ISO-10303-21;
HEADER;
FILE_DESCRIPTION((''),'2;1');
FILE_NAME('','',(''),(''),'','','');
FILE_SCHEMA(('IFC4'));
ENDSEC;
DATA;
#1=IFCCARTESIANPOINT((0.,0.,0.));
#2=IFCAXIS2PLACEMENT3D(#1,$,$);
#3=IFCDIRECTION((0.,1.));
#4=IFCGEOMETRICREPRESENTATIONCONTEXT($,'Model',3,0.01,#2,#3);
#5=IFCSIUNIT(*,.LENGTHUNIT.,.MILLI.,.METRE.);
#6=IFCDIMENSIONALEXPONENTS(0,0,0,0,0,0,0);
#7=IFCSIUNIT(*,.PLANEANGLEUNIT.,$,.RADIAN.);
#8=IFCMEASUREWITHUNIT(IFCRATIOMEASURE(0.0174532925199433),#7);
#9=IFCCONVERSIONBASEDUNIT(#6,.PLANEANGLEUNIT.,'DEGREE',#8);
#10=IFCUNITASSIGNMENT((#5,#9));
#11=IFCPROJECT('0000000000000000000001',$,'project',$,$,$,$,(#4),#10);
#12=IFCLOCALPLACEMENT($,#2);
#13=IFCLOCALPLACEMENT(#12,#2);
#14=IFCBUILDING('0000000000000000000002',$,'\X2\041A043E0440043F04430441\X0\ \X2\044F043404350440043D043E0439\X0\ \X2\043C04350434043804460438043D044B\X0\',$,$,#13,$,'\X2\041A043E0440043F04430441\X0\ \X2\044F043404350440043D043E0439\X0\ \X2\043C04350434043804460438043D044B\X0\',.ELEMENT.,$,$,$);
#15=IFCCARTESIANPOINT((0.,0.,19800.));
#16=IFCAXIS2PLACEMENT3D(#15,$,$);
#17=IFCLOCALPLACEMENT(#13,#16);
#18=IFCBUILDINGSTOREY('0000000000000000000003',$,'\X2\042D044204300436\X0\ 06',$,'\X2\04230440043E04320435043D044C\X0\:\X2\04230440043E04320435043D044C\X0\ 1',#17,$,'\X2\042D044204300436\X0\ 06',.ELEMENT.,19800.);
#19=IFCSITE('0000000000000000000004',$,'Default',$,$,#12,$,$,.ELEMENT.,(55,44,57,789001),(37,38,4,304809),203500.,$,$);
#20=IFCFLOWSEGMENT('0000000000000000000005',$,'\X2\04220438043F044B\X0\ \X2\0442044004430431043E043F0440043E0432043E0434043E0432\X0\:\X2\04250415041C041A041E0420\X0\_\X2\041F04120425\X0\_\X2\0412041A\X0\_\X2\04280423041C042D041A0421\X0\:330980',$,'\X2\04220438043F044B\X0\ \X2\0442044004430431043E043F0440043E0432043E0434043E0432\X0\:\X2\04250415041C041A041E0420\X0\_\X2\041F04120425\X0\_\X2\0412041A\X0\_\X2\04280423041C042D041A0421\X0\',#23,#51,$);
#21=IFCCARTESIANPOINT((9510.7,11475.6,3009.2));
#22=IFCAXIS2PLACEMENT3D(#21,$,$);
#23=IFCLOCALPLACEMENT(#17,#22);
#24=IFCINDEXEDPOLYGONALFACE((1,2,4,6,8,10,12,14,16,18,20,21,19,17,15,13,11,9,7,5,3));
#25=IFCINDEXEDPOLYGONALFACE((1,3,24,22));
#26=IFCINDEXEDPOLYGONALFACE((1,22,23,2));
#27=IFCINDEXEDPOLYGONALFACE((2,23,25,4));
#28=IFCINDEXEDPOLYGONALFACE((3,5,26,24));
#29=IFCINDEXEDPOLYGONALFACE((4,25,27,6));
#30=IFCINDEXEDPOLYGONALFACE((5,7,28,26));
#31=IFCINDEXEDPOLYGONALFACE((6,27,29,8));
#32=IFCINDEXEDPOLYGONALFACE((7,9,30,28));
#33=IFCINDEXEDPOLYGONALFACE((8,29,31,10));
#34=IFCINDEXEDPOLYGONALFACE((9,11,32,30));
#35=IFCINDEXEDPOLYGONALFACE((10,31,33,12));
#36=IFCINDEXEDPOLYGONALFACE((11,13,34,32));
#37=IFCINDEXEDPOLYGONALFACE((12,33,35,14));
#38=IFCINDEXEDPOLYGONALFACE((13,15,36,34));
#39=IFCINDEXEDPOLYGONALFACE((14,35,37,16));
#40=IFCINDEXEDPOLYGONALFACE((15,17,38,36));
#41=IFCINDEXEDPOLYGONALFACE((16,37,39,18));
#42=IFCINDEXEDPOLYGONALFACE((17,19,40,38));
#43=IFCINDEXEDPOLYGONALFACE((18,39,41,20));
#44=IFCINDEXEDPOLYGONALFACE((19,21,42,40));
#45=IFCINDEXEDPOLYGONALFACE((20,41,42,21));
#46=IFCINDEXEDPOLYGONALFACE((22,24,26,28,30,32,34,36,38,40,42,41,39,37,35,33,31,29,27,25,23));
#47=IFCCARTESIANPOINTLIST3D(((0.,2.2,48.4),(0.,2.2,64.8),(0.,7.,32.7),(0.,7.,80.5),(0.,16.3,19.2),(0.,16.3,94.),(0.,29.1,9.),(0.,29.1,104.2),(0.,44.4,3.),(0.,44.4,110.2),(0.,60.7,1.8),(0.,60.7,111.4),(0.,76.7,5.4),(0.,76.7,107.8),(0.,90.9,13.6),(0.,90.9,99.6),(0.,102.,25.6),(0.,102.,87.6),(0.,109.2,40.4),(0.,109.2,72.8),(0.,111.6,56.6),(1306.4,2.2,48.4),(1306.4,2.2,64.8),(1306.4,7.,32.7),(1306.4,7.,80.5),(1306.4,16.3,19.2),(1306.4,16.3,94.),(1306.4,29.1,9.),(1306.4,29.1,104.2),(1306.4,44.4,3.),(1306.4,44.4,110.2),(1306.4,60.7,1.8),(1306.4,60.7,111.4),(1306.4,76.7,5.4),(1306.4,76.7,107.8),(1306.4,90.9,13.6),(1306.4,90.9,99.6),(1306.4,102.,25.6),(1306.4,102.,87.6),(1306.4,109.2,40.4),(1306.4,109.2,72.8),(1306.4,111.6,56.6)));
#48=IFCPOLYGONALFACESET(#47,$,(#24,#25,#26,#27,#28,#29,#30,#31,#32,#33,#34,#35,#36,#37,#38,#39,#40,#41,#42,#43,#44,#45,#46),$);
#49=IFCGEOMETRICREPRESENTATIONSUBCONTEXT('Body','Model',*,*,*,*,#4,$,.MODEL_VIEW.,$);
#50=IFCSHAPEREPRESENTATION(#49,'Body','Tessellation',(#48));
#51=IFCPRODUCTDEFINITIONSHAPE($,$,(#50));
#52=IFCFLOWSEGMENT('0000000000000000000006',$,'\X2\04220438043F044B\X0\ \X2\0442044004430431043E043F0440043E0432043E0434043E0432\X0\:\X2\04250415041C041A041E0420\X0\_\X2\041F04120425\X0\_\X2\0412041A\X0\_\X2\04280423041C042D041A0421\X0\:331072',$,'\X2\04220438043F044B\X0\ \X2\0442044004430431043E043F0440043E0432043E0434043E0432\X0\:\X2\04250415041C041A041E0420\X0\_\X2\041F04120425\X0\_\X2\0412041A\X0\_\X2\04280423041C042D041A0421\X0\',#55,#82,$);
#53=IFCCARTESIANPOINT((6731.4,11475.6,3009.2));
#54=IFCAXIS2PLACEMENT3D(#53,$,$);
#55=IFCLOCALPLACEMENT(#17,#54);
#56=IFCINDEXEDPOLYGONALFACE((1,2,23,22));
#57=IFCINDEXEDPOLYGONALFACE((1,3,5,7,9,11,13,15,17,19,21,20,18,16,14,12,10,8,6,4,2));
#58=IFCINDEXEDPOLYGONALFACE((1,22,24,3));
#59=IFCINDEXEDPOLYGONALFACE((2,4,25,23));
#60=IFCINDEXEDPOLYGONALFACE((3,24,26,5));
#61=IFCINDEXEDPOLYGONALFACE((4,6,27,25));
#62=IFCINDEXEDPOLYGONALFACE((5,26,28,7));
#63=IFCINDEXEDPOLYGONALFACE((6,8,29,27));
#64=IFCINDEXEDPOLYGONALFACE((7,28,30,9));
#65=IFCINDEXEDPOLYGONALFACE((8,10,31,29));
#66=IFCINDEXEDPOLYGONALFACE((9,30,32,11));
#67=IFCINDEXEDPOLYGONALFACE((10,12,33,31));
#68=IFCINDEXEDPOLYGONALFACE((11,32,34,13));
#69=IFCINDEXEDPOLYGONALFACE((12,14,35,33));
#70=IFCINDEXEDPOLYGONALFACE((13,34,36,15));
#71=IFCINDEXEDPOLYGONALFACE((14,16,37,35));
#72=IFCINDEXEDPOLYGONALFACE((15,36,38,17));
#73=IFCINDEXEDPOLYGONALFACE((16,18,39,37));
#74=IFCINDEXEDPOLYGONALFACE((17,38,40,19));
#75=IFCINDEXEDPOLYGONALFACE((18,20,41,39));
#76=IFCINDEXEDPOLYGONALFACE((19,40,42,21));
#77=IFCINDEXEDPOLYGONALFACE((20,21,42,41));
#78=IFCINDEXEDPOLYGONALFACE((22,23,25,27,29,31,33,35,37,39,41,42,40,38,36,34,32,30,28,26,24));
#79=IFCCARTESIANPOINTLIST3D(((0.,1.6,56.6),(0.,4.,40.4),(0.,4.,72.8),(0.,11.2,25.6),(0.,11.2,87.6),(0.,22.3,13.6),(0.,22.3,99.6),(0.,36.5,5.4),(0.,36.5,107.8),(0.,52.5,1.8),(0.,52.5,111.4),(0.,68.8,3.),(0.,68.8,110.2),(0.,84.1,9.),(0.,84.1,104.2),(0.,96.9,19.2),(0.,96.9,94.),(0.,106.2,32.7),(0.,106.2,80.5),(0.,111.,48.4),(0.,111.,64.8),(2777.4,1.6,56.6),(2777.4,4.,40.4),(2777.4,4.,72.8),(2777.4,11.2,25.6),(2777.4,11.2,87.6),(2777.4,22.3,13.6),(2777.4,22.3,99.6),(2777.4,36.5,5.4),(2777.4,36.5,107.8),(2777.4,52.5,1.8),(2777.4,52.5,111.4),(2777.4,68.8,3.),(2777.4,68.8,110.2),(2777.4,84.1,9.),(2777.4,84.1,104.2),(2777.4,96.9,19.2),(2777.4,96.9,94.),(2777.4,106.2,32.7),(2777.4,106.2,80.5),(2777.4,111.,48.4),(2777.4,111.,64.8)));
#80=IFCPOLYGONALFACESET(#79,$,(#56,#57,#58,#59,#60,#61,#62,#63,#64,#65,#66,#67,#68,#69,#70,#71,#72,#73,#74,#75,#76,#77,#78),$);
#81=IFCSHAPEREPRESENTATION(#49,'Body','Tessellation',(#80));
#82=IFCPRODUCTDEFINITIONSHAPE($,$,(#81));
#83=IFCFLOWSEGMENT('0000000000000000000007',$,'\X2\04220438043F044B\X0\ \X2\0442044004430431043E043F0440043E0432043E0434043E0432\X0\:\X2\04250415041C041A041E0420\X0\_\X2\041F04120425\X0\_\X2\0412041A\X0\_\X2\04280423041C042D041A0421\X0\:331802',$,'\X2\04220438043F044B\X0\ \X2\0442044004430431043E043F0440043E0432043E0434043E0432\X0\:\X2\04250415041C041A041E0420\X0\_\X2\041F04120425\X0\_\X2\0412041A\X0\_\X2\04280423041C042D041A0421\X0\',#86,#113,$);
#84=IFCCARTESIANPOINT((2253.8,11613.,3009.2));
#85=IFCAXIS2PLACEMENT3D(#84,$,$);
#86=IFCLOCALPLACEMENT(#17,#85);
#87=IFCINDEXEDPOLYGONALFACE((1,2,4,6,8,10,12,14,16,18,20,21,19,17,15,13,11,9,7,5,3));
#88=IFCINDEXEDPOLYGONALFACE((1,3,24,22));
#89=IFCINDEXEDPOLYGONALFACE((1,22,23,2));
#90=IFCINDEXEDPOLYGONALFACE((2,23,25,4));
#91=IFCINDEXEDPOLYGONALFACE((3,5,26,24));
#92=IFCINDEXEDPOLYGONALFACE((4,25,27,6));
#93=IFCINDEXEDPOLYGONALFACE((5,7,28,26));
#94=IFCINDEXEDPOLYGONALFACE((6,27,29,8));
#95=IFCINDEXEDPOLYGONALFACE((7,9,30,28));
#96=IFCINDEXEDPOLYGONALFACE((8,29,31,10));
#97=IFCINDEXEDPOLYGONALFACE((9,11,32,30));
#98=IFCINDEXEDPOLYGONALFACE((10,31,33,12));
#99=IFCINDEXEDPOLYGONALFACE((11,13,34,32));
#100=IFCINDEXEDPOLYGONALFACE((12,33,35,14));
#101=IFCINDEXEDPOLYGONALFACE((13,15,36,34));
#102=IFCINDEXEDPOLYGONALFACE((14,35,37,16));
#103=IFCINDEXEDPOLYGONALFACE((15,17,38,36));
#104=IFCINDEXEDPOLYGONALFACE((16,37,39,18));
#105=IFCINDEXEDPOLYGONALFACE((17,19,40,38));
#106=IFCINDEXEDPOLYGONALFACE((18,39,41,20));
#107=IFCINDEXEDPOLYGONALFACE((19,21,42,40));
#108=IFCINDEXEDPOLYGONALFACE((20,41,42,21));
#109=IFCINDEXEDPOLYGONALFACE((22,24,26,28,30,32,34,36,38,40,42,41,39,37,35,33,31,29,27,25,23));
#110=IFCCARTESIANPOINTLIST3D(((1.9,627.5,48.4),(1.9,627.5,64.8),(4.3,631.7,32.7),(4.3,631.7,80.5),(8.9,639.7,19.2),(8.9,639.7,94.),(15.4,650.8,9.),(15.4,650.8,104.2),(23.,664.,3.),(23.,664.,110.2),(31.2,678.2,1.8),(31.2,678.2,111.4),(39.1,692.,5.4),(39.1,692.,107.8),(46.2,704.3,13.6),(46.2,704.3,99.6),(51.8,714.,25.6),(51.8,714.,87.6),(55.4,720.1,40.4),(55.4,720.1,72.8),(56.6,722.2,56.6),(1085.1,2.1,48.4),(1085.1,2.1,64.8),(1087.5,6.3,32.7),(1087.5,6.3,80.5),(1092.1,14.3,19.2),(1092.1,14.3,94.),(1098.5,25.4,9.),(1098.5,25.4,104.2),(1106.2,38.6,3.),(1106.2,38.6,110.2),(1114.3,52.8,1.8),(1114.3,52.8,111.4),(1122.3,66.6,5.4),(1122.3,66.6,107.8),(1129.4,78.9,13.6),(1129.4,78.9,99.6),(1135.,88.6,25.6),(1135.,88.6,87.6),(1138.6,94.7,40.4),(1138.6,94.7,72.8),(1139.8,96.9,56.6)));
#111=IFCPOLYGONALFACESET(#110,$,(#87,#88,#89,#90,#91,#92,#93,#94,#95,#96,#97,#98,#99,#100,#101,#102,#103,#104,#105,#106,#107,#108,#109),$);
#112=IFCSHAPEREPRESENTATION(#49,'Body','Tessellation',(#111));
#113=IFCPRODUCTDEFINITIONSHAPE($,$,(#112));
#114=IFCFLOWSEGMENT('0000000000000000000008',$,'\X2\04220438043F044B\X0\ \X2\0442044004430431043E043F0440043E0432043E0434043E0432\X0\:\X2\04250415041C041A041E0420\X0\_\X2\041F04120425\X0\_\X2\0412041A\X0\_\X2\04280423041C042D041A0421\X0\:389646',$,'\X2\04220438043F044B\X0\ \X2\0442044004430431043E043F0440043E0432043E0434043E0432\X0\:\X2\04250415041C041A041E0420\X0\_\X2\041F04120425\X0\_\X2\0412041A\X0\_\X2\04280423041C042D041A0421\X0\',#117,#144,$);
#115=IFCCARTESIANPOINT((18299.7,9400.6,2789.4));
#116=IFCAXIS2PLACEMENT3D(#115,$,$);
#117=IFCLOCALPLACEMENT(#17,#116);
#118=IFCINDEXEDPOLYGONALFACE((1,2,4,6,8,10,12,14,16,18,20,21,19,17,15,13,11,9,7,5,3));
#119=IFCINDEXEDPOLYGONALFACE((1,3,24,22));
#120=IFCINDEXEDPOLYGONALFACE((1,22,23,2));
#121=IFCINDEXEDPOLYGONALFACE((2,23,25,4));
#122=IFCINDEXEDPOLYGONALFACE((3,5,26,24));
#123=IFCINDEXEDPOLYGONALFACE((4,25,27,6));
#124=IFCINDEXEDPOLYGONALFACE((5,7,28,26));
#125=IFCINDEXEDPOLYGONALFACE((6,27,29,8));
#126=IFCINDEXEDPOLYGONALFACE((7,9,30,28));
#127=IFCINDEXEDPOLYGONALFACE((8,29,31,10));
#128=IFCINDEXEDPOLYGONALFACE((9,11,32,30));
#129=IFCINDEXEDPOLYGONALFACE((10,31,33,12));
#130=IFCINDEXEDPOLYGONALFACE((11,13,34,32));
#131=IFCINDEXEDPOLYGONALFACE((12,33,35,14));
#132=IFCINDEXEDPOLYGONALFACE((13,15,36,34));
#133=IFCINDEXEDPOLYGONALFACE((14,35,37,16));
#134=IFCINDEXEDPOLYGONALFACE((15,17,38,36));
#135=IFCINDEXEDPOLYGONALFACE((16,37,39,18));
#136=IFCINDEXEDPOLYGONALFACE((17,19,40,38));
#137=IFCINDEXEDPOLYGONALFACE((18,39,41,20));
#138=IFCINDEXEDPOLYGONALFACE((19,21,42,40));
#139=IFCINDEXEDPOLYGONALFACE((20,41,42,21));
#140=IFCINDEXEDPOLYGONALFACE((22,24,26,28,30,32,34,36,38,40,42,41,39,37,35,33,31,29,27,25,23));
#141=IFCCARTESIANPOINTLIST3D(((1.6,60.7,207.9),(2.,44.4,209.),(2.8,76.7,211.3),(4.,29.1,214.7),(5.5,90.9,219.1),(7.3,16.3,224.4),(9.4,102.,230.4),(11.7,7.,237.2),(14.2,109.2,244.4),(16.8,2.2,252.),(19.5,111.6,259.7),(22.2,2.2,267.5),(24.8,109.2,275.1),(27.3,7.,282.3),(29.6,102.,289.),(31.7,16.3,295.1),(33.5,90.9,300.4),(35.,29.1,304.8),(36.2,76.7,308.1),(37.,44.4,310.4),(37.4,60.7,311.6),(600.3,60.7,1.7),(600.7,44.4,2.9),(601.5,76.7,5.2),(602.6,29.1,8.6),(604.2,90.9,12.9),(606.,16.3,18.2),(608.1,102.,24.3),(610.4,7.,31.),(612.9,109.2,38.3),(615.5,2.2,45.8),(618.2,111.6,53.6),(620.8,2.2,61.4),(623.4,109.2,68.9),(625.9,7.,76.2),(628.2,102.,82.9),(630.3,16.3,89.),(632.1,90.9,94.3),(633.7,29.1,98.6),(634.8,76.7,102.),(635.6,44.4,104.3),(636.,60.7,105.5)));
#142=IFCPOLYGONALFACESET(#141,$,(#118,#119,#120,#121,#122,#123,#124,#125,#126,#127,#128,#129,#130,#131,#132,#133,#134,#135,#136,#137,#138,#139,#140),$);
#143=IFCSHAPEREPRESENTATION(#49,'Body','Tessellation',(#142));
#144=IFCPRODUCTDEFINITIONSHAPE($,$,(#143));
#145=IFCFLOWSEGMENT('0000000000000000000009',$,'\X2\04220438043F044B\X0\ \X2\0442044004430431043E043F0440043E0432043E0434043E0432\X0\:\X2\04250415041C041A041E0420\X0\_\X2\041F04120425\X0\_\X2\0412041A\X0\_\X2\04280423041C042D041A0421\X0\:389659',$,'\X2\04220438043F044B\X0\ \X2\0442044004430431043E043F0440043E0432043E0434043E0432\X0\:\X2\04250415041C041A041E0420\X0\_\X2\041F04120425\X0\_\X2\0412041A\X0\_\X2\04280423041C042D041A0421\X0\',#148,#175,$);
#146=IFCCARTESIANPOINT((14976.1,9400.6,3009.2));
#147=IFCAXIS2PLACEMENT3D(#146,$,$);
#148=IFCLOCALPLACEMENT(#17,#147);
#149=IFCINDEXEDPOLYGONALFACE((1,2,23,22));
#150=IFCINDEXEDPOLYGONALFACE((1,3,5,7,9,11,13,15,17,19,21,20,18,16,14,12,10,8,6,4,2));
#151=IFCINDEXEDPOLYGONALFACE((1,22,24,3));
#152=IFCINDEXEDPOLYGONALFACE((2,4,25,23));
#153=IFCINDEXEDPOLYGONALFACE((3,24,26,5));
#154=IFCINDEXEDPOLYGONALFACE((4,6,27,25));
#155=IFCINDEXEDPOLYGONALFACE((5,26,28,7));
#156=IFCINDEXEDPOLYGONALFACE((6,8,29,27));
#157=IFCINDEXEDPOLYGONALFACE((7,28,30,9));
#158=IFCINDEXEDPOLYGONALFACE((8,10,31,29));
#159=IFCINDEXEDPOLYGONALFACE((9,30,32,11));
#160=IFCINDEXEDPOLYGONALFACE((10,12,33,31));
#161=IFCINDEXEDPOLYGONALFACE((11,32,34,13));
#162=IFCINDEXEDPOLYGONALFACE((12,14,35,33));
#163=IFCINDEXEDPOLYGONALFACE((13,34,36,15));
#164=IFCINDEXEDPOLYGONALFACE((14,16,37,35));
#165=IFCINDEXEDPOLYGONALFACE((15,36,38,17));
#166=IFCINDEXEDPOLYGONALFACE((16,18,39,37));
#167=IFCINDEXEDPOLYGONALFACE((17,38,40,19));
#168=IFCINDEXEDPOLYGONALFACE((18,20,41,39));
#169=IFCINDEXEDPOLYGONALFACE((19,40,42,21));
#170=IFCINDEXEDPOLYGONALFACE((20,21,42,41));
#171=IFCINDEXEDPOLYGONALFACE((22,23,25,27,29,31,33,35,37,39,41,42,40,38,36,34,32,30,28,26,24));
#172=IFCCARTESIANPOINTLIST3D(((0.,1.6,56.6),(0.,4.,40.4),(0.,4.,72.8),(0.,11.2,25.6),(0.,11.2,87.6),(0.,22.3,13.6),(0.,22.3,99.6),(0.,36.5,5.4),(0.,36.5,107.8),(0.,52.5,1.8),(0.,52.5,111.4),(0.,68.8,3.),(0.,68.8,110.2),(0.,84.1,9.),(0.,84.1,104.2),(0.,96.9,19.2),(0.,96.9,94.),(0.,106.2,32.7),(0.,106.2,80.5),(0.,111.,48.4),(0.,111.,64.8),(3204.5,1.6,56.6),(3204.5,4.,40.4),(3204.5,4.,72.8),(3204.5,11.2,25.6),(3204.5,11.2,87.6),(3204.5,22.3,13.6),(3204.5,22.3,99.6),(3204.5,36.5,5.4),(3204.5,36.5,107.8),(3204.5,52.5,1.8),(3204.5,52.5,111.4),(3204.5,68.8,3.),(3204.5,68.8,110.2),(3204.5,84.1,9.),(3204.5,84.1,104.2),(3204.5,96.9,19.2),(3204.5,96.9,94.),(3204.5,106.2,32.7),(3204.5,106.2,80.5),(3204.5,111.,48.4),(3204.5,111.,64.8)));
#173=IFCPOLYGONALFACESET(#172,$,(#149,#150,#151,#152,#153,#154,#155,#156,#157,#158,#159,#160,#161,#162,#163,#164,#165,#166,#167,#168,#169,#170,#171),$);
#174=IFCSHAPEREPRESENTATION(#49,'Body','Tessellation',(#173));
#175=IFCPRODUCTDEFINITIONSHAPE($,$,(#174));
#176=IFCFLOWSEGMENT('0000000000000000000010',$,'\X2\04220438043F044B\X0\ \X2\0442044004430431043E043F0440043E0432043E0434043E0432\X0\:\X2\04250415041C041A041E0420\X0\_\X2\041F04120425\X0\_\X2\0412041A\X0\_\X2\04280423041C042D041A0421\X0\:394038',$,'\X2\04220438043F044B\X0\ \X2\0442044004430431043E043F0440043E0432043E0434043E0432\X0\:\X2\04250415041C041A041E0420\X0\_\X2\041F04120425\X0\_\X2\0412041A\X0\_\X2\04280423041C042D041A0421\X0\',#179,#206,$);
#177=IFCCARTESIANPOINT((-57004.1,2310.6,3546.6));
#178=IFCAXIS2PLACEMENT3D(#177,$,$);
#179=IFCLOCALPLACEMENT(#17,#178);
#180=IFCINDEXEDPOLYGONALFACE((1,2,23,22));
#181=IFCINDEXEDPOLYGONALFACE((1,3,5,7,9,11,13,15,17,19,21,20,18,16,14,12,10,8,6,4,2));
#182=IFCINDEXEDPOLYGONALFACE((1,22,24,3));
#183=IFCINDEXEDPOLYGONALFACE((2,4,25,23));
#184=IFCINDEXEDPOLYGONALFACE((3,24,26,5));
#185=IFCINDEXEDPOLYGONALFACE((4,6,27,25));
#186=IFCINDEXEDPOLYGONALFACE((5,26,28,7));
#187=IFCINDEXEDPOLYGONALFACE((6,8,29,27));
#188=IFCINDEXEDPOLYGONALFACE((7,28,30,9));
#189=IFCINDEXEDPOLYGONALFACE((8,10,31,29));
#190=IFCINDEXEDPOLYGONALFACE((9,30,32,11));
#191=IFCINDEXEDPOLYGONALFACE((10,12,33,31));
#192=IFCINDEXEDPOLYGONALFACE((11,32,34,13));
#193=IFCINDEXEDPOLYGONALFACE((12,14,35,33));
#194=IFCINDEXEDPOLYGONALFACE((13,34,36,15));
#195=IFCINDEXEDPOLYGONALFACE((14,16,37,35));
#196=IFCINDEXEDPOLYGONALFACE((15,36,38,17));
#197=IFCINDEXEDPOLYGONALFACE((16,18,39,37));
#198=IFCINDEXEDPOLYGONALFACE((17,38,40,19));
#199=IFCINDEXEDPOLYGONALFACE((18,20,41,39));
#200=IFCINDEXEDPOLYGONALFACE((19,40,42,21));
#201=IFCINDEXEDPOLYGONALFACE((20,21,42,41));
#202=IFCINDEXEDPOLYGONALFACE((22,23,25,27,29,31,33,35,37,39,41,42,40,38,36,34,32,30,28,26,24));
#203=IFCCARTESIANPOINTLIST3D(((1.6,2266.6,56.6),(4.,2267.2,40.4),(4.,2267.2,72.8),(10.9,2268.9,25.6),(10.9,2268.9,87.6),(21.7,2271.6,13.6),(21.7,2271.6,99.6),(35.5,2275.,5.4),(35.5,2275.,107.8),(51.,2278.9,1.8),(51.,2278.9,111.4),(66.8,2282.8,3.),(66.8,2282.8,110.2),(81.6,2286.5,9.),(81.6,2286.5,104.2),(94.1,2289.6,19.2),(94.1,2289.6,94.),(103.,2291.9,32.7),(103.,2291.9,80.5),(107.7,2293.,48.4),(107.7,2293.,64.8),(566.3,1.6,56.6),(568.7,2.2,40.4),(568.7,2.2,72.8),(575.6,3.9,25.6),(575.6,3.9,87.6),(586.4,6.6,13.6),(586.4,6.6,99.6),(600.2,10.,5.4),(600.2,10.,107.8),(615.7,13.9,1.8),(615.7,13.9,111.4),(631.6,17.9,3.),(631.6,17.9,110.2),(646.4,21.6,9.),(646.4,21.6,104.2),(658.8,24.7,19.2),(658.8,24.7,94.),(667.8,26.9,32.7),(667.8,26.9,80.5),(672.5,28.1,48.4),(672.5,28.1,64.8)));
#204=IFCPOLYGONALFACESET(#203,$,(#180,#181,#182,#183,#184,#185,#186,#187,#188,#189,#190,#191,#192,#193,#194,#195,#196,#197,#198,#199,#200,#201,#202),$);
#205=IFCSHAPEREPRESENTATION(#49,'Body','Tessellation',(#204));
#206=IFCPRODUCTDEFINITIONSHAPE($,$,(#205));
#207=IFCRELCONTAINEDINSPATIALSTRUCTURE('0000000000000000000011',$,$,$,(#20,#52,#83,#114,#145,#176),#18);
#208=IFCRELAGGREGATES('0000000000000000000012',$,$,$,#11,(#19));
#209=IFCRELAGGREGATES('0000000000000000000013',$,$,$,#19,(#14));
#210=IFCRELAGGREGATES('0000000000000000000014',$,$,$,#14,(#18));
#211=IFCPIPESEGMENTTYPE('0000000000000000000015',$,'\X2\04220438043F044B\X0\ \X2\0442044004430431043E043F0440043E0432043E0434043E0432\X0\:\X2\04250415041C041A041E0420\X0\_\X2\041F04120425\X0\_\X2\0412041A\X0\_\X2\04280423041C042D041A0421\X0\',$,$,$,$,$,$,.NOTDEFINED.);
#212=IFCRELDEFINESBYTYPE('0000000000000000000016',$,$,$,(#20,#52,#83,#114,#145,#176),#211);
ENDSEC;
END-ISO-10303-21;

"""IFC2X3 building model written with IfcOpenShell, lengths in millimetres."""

from ifc_helpers import new_model, entity, si_unit, converted_unit, direction, frame, origin, origin_2d_with_axis, place, context, subcontext, project, spatial, circle, extrude, type_object, element, save


model = new_model("IFC2X3")

# Units and contexts
model_context = context("Model", 3, precision=0.01, world=origin(), true_north=direction((0.0, 1.0)))
body_context = subcontext(model_context, "Body", "Model", "MODEL_VIEW")
ifc_project = project(units=[si_unit("LENGTHUNIT", "METRE", prefix="MILLI"), converted_unit("PLANEANGLEUNIT", "DEGREE", entity("IfcRatioMeasure", 0.0174532925199433), si_unit("PLANEANGLEUNIT", "RADIAN"), dimensions=[0, 0, 0, 0, 0, 0, 0])], contexts=[model_context])

# Site, building, storey
site_placement = place(None, origin())
site = spatial("IfcSite", under=ifc_project, at=site_placement, Name="Default", CompositionType="ELEMENT", RefLatitude=(55, 44, 57, 789001), RefLongitude=(37, 38, 4, 304809), RefElevation=203500.0)
building_placement = place(site_placement, origin())
building = spatial("IfcBuilding", under=site, at=building_placement, Name="Корпус ядерной медицины", LongName="Корпус ядерной медицины", CompositionType="ELEMENT")
storey_placement = place(building_placement, frame((0.0, 0.0, 19800.0)))
storey = spatial("IfcBuildingStorey", under=building, at=storey_placement, Name="Этаж 06", ObjectType="Уровень:Уровень 1", LongName="Этаж 06", CompositionType="ELEMENT", Elevation=19800.0)

# Flow segments
pipe_segment_type = type_object("IfcPipeSegmentType", Name="Типы трубопроводов:ХЕМКОР_ПВХ_ВК_ШУМЭКС", PredefinedType="NOTDEFINED")
flow_segment_1_placement = place(storey_placement, frame((9510.7, 11475.6, 3009.2)))
element("IfcFlowSegment", 1, at=flow_segment_1_placement, inside=storey, type_object=pipe_segment_type, Name="Типы трубопроводов:ХЕМКОР_ПВХ_ВК_ШУМЭКС:330980", ObjectType="Типы трубопроводов:ХЕМКОР_ПВХ_ВК_ШУМЭКС", context=body_context, shape_type="SweptSolid", body=[
    extrude(circle(Radius=55.0, at=origin_2d_with_axis()), frame((0.0, 56.6, 56.6), z_axis=(1.0, 0.0, 0.0), x_axis=(0.0, 1.0, 0.0)), (0.0, 0.0, 1.0), 1306.4),
])
flow_segment_2_placement = place(storey_placement, frame((6731.4, 11475.6, 3009.2)))
element("IfcFlowSegment", 2, at=flow_segment_2_placement, inside=storey, type_object=pipe_segment_type, Name="Типы трубопроводов:ХЕМКОР_ПВХ_ВК_ШУМЭКС:331072", ObjectType="Типы трубопроводов:ХЕМКОР_ПВХ_ВК_ШУМЭКС", context=body_context, shape_type="SweptSolid", body=[
    extrude(circle(Radius=55.0, at=origin_2d_with_axis()), frame((0.0, 56.6, 56.6), z_axis=(1.0, 0.0, 0.0), x_axis=(0.0, -1.0, 0.0)), (0.0, 0.0, 1.0), 2777.4),
])
flow_segment_3_placement = place(storey_placement, frame((2253.8, 11613.0, 3009.2)))
element("IfcFlowSegment", 3, at=flow_segment_3_placement, inside=storey, type_object=pipe_segment_type, Name="Типы трубопроводов:ХЕМКОР_ПВХ_ВК_ШУМЭКС:331802", ObjectType="Типы трубопроводов:ХЕМКОР_ПВХ_ВК_ШУМЭКС", context=body_context, shape_type="SweptSolid", body=[
    extrude(circle(Radius=55.0, at=origin_2d_with_axis()), frame((29.1, 674.6, 56.6), z_axis=(0.866025, -0.5, 0.0), x_axis=(0.5, 0.866025, 0.0)), (0.0, 0.0, 1.0), 1250.8),
])
flow_segment_4_placement = place(storey_placement, frame((18299.7, 9400.6, 2789.4)))
element("IfcFlowSegment", 4, at=flow_segment_4_placement, inside=storey, type_object=pipe_segment_type, Name="Типы трубопроводов:ХЕМКОР_ПВХ_ВК_ШУМЭКС:389646", ObjectType="Типы трубопроводов:ХЕМКОР_ПВХ_ВК_ШУМЭКС", context=body_context, shape_type="SweptSolid", body=[
    extrude(circle(Radius=55.0, at=origin_2d_with_axis()), frame((618.1, 56.6, 53.6), z_axis=(-0.945519, 0.0, 0.325568), x_axis=(0.0, 1.0, 0.0)), (0.0, 0.0, 1.0), 633.1),
])
flow_segment_5_placement = place(storey_placement, frame((14976.1, 9400.6, 3009.2)))
element("IfcFlowSegment", 5, at=flow_segment_5_placement, inside=storey, type_object=pipe_segment_type, Name="Типы трубопроводов:ХЕМКОР_ПВХ_ВК_ШУМЭКС:389659", ObjectType="Типы трубопроводов:ХЕМКОР_ПВХ_ВК_ШУМЭКС", context=body_context, shape_type="SweptSolid", body=[
    extrude(circle(Radius=55.0, at=origin_2d_with_axis()), frame((0.0, 56.6, 56.6), z_axis=(1.0, 0.0, 0.0), x_axis=(0.0, -1.0, 0.0)), (0.0, 0.0, 1.0), 3204.5),
])
flow_segment_6_placement = place(storey_placement, frame((-57004.1, 2310.6, 3546.6)))
element("IfcFlowSegment", 6, at=flow_segment_6_placement, inside=storey, type_object=pipe_segment_type, Name="Типы трубопроводов:ХЕМКОР_ПВХ_ВК_ШУМЭКС:394038", ObjectType="Типы трубопроводов:ХЕМКОР_ПВХ_ВК_ШУМЭКС", context=body_context, shape_type="SweptSolid", body=[
    extrude(circle(Radius=55.0, at=origin_2d_with_axis()), frame((619.7, 14.9, 56.6), z_axis=(-0.241922, 0.970296, 0.0), x_axis=(-0.970296, -0.241922, 0.0)), (0.0, 0.0, 1.0), 2334.3),
])

save(model, "model.ifc")
